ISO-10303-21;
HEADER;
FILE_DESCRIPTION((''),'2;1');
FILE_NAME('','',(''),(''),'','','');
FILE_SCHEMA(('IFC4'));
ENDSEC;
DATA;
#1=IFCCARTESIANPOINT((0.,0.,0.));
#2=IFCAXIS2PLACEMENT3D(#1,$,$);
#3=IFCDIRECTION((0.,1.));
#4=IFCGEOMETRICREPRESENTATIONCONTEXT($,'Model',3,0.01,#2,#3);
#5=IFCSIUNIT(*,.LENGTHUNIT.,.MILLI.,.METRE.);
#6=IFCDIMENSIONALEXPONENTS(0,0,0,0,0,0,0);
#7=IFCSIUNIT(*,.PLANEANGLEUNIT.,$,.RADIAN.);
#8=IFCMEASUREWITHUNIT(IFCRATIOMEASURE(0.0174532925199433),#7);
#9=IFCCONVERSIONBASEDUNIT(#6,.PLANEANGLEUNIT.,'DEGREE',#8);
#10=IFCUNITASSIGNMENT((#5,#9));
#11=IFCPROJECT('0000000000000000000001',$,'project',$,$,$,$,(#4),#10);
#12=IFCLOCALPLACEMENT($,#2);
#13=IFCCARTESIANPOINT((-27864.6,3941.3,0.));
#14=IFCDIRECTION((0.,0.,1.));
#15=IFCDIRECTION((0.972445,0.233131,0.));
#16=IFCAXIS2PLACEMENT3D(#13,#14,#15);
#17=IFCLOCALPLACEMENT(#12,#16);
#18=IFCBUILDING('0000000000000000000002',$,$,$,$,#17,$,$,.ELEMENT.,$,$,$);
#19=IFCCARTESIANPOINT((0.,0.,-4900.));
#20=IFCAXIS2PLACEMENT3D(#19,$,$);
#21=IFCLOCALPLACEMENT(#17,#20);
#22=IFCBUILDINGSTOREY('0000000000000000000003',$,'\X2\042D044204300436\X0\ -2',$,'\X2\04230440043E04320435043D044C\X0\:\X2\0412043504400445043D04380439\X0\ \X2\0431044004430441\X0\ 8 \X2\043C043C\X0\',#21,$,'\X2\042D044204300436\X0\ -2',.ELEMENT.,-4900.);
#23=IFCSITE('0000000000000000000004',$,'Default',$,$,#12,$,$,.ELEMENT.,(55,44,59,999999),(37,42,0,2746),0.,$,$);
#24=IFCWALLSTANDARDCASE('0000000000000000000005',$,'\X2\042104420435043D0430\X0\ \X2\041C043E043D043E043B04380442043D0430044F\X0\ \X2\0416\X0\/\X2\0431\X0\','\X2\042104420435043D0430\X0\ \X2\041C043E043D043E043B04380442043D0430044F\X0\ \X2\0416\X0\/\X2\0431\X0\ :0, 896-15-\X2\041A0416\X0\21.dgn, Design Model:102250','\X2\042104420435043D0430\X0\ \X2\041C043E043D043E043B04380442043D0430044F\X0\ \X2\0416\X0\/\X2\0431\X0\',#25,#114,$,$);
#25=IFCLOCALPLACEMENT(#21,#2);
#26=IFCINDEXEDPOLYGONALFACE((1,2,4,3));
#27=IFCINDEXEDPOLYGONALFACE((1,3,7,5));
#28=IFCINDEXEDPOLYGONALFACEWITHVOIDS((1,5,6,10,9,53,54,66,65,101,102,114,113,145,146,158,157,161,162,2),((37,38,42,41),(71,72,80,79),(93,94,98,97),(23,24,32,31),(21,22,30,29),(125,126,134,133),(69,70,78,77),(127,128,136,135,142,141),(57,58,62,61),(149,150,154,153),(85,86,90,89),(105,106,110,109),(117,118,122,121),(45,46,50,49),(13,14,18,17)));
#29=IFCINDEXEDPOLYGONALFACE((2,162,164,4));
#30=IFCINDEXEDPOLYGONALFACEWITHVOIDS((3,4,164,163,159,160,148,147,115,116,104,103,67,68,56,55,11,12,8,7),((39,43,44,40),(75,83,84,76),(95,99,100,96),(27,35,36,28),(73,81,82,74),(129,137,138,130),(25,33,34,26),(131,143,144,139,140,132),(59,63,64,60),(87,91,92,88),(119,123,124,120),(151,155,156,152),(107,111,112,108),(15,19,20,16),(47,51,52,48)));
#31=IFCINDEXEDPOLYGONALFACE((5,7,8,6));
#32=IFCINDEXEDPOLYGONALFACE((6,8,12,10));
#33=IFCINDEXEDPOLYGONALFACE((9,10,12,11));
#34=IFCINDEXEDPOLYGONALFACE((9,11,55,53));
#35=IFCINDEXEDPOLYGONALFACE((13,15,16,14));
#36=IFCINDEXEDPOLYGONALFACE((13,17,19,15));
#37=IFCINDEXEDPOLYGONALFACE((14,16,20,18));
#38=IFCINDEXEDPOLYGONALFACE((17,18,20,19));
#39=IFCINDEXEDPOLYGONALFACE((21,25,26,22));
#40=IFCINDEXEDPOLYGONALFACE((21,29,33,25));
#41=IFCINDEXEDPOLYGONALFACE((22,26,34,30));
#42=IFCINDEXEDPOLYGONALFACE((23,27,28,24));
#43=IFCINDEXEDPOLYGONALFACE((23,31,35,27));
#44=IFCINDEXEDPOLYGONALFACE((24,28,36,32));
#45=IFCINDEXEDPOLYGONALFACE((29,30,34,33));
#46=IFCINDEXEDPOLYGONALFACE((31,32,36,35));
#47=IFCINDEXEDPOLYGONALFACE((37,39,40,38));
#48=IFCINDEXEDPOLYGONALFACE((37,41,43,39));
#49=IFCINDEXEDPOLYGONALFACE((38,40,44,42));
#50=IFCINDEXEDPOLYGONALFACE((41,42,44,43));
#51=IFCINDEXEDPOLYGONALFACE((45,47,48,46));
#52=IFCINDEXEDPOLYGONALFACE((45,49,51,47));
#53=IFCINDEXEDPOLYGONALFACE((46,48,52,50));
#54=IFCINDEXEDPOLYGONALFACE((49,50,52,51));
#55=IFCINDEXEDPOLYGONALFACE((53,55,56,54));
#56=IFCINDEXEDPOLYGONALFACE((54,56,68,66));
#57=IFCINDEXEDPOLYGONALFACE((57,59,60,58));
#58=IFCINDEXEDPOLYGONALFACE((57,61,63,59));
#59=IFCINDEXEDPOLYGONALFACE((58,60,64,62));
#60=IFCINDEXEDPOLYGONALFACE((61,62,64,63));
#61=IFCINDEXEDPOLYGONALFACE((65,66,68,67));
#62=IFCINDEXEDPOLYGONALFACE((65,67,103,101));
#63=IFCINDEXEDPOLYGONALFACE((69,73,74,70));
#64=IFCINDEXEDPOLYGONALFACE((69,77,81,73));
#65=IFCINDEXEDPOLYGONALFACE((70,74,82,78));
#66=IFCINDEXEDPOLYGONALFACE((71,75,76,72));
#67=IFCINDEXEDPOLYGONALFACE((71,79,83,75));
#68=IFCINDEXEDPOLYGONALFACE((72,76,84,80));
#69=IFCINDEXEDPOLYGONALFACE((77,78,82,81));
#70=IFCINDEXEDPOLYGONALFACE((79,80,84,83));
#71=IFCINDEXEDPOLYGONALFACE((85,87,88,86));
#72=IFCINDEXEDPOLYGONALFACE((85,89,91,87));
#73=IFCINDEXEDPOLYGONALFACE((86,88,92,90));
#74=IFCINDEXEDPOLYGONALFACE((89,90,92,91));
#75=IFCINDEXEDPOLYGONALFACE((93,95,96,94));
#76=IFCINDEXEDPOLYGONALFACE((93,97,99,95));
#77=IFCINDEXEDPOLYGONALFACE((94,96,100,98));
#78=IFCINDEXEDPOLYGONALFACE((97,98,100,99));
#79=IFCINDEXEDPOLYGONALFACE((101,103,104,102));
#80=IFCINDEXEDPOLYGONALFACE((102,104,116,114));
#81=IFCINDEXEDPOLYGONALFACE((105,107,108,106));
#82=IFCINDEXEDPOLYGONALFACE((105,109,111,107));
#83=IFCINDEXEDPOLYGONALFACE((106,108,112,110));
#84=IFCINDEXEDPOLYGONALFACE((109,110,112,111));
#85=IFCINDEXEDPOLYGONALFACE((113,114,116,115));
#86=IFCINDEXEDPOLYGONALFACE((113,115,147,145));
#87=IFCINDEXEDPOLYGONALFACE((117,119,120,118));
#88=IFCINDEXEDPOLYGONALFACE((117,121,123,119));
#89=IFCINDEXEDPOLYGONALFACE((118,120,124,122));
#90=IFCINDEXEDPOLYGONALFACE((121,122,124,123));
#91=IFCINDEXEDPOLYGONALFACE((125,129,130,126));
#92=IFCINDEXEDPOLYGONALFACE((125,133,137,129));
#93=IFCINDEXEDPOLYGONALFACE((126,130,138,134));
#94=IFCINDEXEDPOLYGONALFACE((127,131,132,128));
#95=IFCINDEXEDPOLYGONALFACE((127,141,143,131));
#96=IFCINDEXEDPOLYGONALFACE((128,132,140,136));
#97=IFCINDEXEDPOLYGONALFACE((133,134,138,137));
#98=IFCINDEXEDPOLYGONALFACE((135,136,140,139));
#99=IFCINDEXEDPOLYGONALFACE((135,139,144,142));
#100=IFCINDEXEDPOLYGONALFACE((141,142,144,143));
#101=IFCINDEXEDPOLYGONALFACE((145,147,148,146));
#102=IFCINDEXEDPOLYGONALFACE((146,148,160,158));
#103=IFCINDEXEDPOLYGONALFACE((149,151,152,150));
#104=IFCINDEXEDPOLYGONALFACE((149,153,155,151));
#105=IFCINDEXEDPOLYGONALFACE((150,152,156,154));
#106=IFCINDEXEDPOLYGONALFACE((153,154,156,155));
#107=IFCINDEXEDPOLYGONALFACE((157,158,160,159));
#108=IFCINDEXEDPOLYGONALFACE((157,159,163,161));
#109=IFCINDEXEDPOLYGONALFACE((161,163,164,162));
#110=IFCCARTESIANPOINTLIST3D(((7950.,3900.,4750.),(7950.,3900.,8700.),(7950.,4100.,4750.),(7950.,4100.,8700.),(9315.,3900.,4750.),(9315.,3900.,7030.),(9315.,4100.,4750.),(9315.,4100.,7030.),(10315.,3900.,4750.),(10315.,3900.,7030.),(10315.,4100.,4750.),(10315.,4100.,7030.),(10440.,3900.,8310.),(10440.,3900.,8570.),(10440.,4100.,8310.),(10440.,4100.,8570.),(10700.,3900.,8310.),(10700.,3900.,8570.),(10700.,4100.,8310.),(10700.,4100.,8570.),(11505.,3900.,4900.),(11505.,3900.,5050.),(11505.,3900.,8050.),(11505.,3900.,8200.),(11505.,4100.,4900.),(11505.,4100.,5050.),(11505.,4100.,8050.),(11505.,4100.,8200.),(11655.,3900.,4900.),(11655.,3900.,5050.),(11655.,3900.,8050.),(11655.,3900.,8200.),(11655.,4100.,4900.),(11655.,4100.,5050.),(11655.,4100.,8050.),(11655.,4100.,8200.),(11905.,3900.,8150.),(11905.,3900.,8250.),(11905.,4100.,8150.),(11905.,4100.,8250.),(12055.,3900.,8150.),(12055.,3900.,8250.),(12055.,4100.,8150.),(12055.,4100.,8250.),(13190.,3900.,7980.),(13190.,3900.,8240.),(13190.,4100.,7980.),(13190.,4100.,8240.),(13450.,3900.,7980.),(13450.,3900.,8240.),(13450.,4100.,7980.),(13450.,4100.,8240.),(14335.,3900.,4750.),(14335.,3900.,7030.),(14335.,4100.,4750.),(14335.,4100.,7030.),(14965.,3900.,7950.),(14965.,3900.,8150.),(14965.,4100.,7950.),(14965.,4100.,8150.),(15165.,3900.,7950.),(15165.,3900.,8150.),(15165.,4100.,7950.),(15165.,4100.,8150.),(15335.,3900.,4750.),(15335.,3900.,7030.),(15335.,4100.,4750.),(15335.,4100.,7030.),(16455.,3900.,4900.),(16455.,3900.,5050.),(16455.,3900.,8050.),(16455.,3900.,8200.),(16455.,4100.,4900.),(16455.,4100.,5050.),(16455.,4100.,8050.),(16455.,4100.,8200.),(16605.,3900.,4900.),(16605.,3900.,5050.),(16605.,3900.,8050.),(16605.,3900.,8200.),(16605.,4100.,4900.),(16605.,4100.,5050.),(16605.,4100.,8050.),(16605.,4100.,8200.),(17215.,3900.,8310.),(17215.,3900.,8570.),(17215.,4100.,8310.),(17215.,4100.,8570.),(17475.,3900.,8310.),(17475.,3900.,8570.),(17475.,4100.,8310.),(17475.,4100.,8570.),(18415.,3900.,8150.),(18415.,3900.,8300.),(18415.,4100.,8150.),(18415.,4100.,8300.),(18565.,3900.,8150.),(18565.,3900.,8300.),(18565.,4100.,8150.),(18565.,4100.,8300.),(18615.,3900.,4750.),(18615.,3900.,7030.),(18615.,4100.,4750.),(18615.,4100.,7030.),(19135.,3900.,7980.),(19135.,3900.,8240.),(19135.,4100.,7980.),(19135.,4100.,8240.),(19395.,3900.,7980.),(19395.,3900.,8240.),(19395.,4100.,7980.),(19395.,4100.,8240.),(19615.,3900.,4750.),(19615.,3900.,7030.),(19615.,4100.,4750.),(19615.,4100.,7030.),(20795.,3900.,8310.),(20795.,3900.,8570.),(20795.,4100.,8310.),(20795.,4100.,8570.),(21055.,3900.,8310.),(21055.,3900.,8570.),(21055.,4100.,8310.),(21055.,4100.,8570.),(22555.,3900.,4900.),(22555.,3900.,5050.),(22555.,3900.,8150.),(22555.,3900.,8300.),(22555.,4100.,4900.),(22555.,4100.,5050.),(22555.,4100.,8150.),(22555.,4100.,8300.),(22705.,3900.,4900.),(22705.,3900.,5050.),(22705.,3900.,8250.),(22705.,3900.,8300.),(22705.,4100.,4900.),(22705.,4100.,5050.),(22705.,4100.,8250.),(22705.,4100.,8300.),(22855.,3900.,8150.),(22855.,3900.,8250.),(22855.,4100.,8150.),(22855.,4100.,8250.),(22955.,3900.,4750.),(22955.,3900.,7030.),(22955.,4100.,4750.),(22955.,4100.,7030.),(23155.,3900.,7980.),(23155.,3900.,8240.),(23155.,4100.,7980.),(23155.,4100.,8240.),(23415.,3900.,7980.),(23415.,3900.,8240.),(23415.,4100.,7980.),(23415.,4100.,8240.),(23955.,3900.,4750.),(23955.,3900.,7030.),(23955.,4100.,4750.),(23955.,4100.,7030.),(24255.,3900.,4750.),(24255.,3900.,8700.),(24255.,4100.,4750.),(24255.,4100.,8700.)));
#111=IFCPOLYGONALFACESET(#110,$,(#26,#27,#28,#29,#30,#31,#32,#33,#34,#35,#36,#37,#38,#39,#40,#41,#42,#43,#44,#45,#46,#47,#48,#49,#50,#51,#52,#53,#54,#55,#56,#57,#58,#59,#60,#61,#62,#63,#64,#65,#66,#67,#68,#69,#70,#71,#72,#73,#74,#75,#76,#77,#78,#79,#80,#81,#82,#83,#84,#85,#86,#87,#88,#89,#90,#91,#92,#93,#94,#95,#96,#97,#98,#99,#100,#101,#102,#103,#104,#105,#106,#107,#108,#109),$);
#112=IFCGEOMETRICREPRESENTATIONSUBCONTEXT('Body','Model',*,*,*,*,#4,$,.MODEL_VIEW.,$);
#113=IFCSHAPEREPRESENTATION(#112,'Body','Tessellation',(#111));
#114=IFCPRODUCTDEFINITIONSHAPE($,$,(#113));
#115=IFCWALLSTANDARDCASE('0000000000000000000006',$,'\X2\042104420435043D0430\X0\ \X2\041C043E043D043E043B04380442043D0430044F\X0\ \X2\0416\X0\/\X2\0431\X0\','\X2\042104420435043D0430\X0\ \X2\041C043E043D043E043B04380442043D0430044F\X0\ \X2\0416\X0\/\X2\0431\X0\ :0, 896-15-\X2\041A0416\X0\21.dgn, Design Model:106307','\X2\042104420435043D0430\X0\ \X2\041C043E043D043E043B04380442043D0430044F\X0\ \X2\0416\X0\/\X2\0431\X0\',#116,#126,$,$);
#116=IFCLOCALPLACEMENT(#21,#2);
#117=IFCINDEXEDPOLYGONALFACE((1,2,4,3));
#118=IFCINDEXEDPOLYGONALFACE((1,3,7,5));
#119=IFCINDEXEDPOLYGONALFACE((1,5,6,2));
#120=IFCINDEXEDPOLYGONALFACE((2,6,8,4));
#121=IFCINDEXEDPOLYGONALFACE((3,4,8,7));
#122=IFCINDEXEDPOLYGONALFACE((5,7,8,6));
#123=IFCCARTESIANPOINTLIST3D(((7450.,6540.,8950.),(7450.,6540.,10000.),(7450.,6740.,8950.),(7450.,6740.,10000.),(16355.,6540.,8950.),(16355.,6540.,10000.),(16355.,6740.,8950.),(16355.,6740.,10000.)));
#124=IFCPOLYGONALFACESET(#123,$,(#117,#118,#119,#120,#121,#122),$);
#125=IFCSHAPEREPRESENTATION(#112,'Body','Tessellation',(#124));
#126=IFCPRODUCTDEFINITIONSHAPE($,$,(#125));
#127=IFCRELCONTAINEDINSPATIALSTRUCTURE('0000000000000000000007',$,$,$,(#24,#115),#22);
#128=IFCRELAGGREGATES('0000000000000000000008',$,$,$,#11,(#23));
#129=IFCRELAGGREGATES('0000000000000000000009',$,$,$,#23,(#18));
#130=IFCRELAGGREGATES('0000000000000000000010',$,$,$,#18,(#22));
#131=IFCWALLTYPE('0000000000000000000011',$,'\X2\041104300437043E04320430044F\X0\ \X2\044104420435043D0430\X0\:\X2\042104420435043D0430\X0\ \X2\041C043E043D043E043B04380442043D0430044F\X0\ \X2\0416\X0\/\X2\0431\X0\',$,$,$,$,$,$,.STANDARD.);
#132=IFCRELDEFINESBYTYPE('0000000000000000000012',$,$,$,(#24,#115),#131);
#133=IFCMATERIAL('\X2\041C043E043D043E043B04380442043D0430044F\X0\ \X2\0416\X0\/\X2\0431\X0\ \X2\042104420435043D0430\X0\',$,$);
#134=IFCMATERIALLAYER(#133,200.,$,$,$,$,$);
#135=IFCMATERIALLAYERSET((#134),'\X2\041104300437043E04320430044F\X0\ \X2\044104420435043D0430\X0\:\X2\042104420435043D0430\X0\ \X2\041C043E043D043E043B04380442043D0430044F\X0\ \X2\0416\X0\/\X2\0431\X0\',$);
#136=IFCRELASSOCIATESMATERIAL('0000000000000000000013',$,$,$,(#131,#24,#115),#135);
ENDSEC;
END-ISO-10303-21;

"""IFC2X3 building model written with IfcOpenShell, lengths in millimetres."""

from ifc_helpers import new_model, entity, si_unit, converted_unit, direction, frame, frame_2d, origin, origin_2d_with_axis, place, context, subcontext, project, spatial, polyline, rectangle, outline, extrude, material, layer, layer_set, layer_usage, type_object, element, save


model = new_model("IFC2X3")

# Units and contexts
model_context = context("Model", 3, precision=0.01, world=origin(), true_north=direction((0.0, 1.0)))
body_context = subcontext(model_context, "Body", "Model", "MODEL_VIEW")
ifc_project = project(units=[si_unit("LENGTHUNIT", "METRE", prefix="MILLI"), converted_unit("PLANEANGLEUNIT", "DEGREE", entity("IfcRatioMeasure", 0.0174532925199433), si_unit("PLANEANGLEUNIT", "RADIAN"), dimensions=[0, 0, 0, 0, 0, 0, 0])], contexts=[model_context])

# Site, building, storey
site_placement = place(None, origin())
site = spatial("IfcSite", under=ifc_project, at=site_placement, Name="Default", CompositionType="ELEMENT", RefLatitude=(55, 44, 59, 999999), RefLongitude=(37, 42, 0, 2746), RefElevation=0.0)
building_placement = place(site_placement, frame((-27864.6, 3941.3, 0.0), z_axis=(0.0, 0.0, 1.0), x_axis=(0.972445, 0.233131, 0.0)))
building = spatial("IfcBuilding", under=site, at=building_placement, CompositionType="ELEMENT")
storey_placement = place(building_placement, frame((0.0, 0.0, -4900.0)))
storey = spatial("IfcBuildingStorey", under=building, at=storey_placement, Name="Этаж -2", ObjectType="Уровень:Верхний брус 8 мм", LongName="Этаж -2", CompositionType="ELEMENT", Elevation=-4900.0)

# Wall, openings
ifc_material = material(Name="Монолитная Ж/б Стена")
ifc_layer_1 = layer(ifc_material, 200.0)
ifc_layer_set_1 = layer_set([ifc_layer_1], Name="Базовая стена:Стена Монолитная Ж/б")
wall_type_1 = type_object("IfcWallType", Name="Базовая стена:Стена Монолитная Ж/б", PredefinedType="STANDARD", material=ifc_layer_set_1)
ifc_layer_usage_1 = layer_usage(ifc_layer_set_1, "AXIS2", "NEGATIVE", 100.0)
wall_1_placement = place(storey_placement, frame((24255.0, 4000.0, 4750.0), z_axis=(0.0, 0.0, 1.0), x_axis=(-1.0, 0.0, 0.0)))
wall_1 = element("IfcWallStandardCase", 1, at=wall_1_placement, inside=storey, type_object=wall_type_1, material=ifc_layer_usage_1, Name="Стена Монолитная Ж/б", Description="Стена Монолитная Ж/б :0, 896-15-КЖ21.dgn, Design Model:102250", ObjectType="Стена Монолитная Ж/б", context=body_context, shape_type="SweptSolid", body=[
    extrude(rectangle(XDim=16305.0, YDim=200.0, at=frame_2d((8152.5, 0.0), x_axis=(-1.0, 0.0))), origin(), (0.0, 0.0, 1.0), 3950.0),
])
opening_1_placement = place(wall_1_placement, origin())
element("IfcOpeningElement", 2, at=opening_1_placement, cuts=wall_1, ObjectType="Opening", context=body_context, shape_type="SweptSolid", body=[
    extrude(rectangle(XDim=2280.0, YDim=1000.0, at=origin_2d_with_axis()), frame((14440.0, -100.0, 1140.0), z_axis=(0.0, 1.0, 0.0), x_axis=(0.0, 0.0, -1.0)), (0.0, 0.0, 1.0), 200.0),
])
opening_2_placement = place(wall_1_placement, origin())
element("IfcOpeningElement", 3, at=opening_2_placement, cuts=wall_1, ObjectType="Opening", context=body_context, shape_type="SweptSolid", body=[
    extrude(rectangle(XDim=2280.0, YDim=1000.0, at=origin_2d_with_axis()), frame((9420.0, -100.0, 1140.0), z_axis=(0.0, 1.0, 0.0), x_axis=(0.0, 0.0, -1.0)), (0.0, 0.0, 1.0), 200.0),
])
opening_3_placement = place(wall_1_placement, origin())
element("IfcOpeningElement", 4, at=opening_3_placement, cuts=wall_1, ObjectType="Opening", context=body_context, shape_type="SweptSolid", body=[
    extrude(rectangle(XDim=2280.0, YDim=1000.0, at=origin_2d_with_axis()), frame((5140.0, -100.0, 1140.0), z_axis=(0.0, 1.0, 0.0), x_axis=(0.0, 0.0, -1.0)), (0.0, 0.0, 1.0), 200.0),
])
opening_4_placement = place(wall_1_placement, origin())
element("IfcOpeningElement", 5, at=opening_4_placement, cuts=wall_1, ObjectType="Opening", context=body_context, shape_type="SweptSolid", body=[
    extrude(rectangle(XDim=2280.0, YDim=1000.0, at=origin_2d_with_axis()), frame((800.0, -100.0, 1140.0), z_axis=(0.0, 1.0, 0.0), x_axis=(0.0, 0.0, -1.0)), (0.0, 0.0, 1.0), 200.0),
])
opening_5_placement = place(wall_1_placement, origin())
element("IfcOpeningElement", 6, at=opening_5_placement, cuts=wall_1, ObjectType="Opening", context=body_context, shape_type="SweptSolid", body=[
    extrude(rectangle(XDim=200.0, YDim=200.0, at=origin_2d_with_axis()), frame((9190.0, -100.0, 3300.0), z_axis=(0.0, 1.0, 0.0), x_axis=(0.0, 0.0, -1.0)), (0.0, 0.0, 1.0), 200.0),
])
opening_6_placement = place(wall_1_placement, origin())
element("IfcOpeningElement", 7, at=opening_6_placement, cuts=wall_1, ObjectType="Opening", context=body_context, shape_type="SweptSolid", body=[
    extrude(rectangle(XDim=150.0, YDim=150.0, at=origin_2d_with_axis()), frame((7725.0, -100.0, 225.0), z_axis=(0.0, 1.0, 0.0), x_axis=(0.0, 0.0, -1.0)), (0.0, 0.0, 1.0), 200.0),
])
opening_7_placement = place(wall_1_placement, origin())
element("IfcOpeningElement", 8, at=opening_7_placement, cuts=wall_1, ObjectType="Opening", context=body_context, shape_type="SweptSolid", body=[
    extrude(rectangle(XDim=150.0, YDim=150.0, at=origin_2d_with_axis()), frame((7725.0, -100.0, 3375.0), z_axis=(0.0, 1.0, 0.0), x_axis=(0.0, 0.0, -1.0)), (0.0, 0.0, 1.0), 200.0),
])
opening_8_placement = place(wall_1_placement, origin())
element("IfcOpeningElement", 9, at=opening_8_placement, cuts=wall_1, ObjectType="Opening", context=body_context, shape_type="SweptSolid", body=[
    extrude(rectangle(XDim=260.0, YDim=260.0, at=origin_2d_with_axis()), frame((6910.0, -100.0, 3690.0), z_axis=(0.0, 1.0, 0.0), x_axis=(0.0, 0.0, -1.0)), (0.0, 0.0, 1.0), 200.0),
])
opening_9_placement = place(wall_1_placement, origin())
element("IfcOpeningElement", 10, at=opening_9_placement, cuts=wall_1, ObjectType="Opening", context=body_context, shape_type="SweptSolid", body=[
    extrude(rectangle(XDim=150.0, YDim=150.0, at=origin_2d_with_axis()), frame((5765.0, -100.0, 3475.0), z_axis=(0.0, 1.0, 0.0), x_axis=(0.0, 0.0, -1.0)), (0.0, 0.0, 1.0), 200.0),
])
opening_10_placement = place(wall_1_placement, origin())
element("IfcOpeningElement", 11, at=opening_10_placement, cuts=wall_1, ObjectType="Opening", context=body_context, shape_type="SweptSolid", body=[
    extrude(rectangle(XDim=260.0, YDim=260.0, at=origin_2d_with_axis()), frame((4990.0, -100.0, 3360.0), z_axis=(0.0, 1.0, 0.0), x_axis=(0.0, 0.0, -1.0)), (0.0, 0.0, 1.0), 200.0),
])
opening_11_placement = place(wall_1_placement, origin())
element("IfcOpeningElement", 12, at=opening_11_placement, cuts=wall_1, ObjectType="Opening", context=body_context, shape_type="SweptSolid", body=[
    extrude(rectangle(XDim=260.0, YDim=260.0, at=origin_2d_with_axis()), frame((3330.0, -100.0, 3690.0), z_axis=(0.0, 1.0, 0.0), x_axis=(0.0, 0.0, -1.0)), (0.0, 0.0, 1.0), 200.0),
])
opening_12_placement = place(wall_1_placement, origin())
element("IfcOpeningElement", 13, at=opening_12_placement, cuts=wall_1, ObjectType="Opening", context=body_context, shape_type="SweptSolid", body=[
    extrude(rectangle(XDim=260.0, YDim=260.0, at=origin_2d_with_axis()), frame((970.0, -100.0, 3360.0), z_axis=(0.0, 1.0, 0.0), x_axis=(0.0, 0.0, -1.0)), (0.0, 0.0, 1.0), 200.0),
])
opening_13_placement = place(wall_1_placement, origin())
element("IfcOpeningElement", 14, at=opening_13_placement, cuts=wall_1, ObjectType="Opening", context=body_context, shape_type="SweptSolid", body=[
    extrude(rectangle(XDim=150.0, YDim=150.0, at=origin_2d_with_axis()), frame((1625.0, -100.0, 225.0), z_axis=(0.0, 1.0, 0.0), x_axis=(0.0, 0.0, -1.0)), (0.0, 0.0, 1.0), 200.0),
])
opening_14_placement = place(wall_1_placement, origin())
element("IfcOpeningElement", 15, at=opening_14_placement, cuts=wall_1, ObjectType="Opening", context=body_context, shape_type="SweptSolid", body=[
    extrude(rectangle(XDim=260.0, YDim=260.0, at=origin_2d_with_axis()), frame((13685.0, -100.0, 3690.0), z_axis=(0.0, 1.0, 0.0), x_axis=(0.0, 0.0, -1.0)), (0.0, 0.0, 1.0), 200.0),
])
opening_15_placement = place(wall_1_placement, origin())
element("IfcOpeningElement", 16, at=opening_15_placement, cuts=wall_1, ObjectType="Opening", context=body_context, shape_type="SweptSolid", body=[
    extrude(rectangle(XDim=150.0, YDim=150.0, at=origin_2d_with_axis()), frame((12675.0, -100.0, 3375.0), z_axis=(0.0, 1.0, 0.0), x_axis=(0.0, 0.0, -1.0)), (0.0, 0.0, 1.0), 200.0),
])
opening_16_placement = place(wall_1_placement, origin())
element("IfcOpeningElement", 17, at=opening_16_placement, cuts=wall_1, ObjectType="Opening", context=body_context, shape_type="SweptSolid", body=[
    extrude(rectangle(XDim=100.0, YDim=150.0, at=origin_2d_with_axis()), frame((12275.0, -100.0, 3450.0), z_axis=(0.0, 1.0, 0.0), x_axis=(0.0, 0.0, -1.0)), (0.0, 0.0, 1.0), 200.0),
])
opening_17_placement = place(wall_1_placement, origin())
element("IfcOpeningElement", 18, at=opening_17_placement, cuts=wall_1, ObjectType="Opening", context=body_context, shape_type="SweptSolid", body=[
    extrude(rectangle(XDim=150.0, YDim=150.0, at=origin_2d_with_axis()), frame((12675.0, -100.0, 225.0), z_axis=(0.0, 1.0, 0.0), x_axis=(0.0, 0.0, -1.0)), (0.0, 0.0, 1.0), 200.0),
])
opening_18_placement = place(wall_1_placement, origin())
element("IfcOpeningElement", 19, at=opening_18_placement, cuts=wall_1, ObjectType="Opening", context=body_context, shape_type="SweptSolid", body=[
    extrude(rectangle(XDim=260.0, YDim=260.0, at=origin_2d_with_axis()), frame((10935.0, -100.0, 3360.0), z_axis=(0.0, 1.0, 0.0), x_axis=(0.0, 0.0, -1.0)), (0.0, 0.0, 1.0), 200.0),
])
opening_19_placement = place(wall_1_placement, origin())
element("IfcOpeningElement", 20, at=opening_19_placement, cuts=wall_1, ObjectType="Opening", context=body_context, shape_type="SweptSolid", body=[
    extrude(outline(polyline([(16.7, 0.0), (66.7, 0.0), (66.7, 150.0), (-83.3, 150.0), (-83.3, -150.0), (16.7, -150.0), (16.7, 0.0)])), frame((1550.0, -100.0, 3483.3), z_axis=(0.0, 1.0, 0.0), x_axis=(0.0, 0.0, 1.0)), (0.0, 0.0, 1.0), 200.0),
])

# Wall
ifc_layer_usage_2 = layer_usage(ifc_layer_set_1, "AXIS2", "NEGATIVE", 100.0)
wall_2_placement = place(storey_placement, frame((16355.0, 6640.0, 8950.0), z_axis=(0.0, 0.0, 1.0), x_axis=(-1.0, 0.0, 0.0)))
element("IfcWallStandardCase", 21, at=wall_2_placement, inside=storey, type_object=wall_type_1, material=ifc_layer_usage_2, Name="Стена Монолитная Ж/б", Description="Стена Монолитная Ж/б :0, 896-15-КЖ21.dgn, Design Model:106307", ObjectType="Стена Монолитная Ж/б", context=body_context, shape_type="SweptSolid", body=[
    extrude(rectangle(XDim=8905.0, YDim=200.0, at=frame_2d((4452.5, 0.0), x_axis=(-1.0, 0.0))), origin(), (0.0, 0.0, 1.0), 1050.0),
])

save(model, "model.ifc")
